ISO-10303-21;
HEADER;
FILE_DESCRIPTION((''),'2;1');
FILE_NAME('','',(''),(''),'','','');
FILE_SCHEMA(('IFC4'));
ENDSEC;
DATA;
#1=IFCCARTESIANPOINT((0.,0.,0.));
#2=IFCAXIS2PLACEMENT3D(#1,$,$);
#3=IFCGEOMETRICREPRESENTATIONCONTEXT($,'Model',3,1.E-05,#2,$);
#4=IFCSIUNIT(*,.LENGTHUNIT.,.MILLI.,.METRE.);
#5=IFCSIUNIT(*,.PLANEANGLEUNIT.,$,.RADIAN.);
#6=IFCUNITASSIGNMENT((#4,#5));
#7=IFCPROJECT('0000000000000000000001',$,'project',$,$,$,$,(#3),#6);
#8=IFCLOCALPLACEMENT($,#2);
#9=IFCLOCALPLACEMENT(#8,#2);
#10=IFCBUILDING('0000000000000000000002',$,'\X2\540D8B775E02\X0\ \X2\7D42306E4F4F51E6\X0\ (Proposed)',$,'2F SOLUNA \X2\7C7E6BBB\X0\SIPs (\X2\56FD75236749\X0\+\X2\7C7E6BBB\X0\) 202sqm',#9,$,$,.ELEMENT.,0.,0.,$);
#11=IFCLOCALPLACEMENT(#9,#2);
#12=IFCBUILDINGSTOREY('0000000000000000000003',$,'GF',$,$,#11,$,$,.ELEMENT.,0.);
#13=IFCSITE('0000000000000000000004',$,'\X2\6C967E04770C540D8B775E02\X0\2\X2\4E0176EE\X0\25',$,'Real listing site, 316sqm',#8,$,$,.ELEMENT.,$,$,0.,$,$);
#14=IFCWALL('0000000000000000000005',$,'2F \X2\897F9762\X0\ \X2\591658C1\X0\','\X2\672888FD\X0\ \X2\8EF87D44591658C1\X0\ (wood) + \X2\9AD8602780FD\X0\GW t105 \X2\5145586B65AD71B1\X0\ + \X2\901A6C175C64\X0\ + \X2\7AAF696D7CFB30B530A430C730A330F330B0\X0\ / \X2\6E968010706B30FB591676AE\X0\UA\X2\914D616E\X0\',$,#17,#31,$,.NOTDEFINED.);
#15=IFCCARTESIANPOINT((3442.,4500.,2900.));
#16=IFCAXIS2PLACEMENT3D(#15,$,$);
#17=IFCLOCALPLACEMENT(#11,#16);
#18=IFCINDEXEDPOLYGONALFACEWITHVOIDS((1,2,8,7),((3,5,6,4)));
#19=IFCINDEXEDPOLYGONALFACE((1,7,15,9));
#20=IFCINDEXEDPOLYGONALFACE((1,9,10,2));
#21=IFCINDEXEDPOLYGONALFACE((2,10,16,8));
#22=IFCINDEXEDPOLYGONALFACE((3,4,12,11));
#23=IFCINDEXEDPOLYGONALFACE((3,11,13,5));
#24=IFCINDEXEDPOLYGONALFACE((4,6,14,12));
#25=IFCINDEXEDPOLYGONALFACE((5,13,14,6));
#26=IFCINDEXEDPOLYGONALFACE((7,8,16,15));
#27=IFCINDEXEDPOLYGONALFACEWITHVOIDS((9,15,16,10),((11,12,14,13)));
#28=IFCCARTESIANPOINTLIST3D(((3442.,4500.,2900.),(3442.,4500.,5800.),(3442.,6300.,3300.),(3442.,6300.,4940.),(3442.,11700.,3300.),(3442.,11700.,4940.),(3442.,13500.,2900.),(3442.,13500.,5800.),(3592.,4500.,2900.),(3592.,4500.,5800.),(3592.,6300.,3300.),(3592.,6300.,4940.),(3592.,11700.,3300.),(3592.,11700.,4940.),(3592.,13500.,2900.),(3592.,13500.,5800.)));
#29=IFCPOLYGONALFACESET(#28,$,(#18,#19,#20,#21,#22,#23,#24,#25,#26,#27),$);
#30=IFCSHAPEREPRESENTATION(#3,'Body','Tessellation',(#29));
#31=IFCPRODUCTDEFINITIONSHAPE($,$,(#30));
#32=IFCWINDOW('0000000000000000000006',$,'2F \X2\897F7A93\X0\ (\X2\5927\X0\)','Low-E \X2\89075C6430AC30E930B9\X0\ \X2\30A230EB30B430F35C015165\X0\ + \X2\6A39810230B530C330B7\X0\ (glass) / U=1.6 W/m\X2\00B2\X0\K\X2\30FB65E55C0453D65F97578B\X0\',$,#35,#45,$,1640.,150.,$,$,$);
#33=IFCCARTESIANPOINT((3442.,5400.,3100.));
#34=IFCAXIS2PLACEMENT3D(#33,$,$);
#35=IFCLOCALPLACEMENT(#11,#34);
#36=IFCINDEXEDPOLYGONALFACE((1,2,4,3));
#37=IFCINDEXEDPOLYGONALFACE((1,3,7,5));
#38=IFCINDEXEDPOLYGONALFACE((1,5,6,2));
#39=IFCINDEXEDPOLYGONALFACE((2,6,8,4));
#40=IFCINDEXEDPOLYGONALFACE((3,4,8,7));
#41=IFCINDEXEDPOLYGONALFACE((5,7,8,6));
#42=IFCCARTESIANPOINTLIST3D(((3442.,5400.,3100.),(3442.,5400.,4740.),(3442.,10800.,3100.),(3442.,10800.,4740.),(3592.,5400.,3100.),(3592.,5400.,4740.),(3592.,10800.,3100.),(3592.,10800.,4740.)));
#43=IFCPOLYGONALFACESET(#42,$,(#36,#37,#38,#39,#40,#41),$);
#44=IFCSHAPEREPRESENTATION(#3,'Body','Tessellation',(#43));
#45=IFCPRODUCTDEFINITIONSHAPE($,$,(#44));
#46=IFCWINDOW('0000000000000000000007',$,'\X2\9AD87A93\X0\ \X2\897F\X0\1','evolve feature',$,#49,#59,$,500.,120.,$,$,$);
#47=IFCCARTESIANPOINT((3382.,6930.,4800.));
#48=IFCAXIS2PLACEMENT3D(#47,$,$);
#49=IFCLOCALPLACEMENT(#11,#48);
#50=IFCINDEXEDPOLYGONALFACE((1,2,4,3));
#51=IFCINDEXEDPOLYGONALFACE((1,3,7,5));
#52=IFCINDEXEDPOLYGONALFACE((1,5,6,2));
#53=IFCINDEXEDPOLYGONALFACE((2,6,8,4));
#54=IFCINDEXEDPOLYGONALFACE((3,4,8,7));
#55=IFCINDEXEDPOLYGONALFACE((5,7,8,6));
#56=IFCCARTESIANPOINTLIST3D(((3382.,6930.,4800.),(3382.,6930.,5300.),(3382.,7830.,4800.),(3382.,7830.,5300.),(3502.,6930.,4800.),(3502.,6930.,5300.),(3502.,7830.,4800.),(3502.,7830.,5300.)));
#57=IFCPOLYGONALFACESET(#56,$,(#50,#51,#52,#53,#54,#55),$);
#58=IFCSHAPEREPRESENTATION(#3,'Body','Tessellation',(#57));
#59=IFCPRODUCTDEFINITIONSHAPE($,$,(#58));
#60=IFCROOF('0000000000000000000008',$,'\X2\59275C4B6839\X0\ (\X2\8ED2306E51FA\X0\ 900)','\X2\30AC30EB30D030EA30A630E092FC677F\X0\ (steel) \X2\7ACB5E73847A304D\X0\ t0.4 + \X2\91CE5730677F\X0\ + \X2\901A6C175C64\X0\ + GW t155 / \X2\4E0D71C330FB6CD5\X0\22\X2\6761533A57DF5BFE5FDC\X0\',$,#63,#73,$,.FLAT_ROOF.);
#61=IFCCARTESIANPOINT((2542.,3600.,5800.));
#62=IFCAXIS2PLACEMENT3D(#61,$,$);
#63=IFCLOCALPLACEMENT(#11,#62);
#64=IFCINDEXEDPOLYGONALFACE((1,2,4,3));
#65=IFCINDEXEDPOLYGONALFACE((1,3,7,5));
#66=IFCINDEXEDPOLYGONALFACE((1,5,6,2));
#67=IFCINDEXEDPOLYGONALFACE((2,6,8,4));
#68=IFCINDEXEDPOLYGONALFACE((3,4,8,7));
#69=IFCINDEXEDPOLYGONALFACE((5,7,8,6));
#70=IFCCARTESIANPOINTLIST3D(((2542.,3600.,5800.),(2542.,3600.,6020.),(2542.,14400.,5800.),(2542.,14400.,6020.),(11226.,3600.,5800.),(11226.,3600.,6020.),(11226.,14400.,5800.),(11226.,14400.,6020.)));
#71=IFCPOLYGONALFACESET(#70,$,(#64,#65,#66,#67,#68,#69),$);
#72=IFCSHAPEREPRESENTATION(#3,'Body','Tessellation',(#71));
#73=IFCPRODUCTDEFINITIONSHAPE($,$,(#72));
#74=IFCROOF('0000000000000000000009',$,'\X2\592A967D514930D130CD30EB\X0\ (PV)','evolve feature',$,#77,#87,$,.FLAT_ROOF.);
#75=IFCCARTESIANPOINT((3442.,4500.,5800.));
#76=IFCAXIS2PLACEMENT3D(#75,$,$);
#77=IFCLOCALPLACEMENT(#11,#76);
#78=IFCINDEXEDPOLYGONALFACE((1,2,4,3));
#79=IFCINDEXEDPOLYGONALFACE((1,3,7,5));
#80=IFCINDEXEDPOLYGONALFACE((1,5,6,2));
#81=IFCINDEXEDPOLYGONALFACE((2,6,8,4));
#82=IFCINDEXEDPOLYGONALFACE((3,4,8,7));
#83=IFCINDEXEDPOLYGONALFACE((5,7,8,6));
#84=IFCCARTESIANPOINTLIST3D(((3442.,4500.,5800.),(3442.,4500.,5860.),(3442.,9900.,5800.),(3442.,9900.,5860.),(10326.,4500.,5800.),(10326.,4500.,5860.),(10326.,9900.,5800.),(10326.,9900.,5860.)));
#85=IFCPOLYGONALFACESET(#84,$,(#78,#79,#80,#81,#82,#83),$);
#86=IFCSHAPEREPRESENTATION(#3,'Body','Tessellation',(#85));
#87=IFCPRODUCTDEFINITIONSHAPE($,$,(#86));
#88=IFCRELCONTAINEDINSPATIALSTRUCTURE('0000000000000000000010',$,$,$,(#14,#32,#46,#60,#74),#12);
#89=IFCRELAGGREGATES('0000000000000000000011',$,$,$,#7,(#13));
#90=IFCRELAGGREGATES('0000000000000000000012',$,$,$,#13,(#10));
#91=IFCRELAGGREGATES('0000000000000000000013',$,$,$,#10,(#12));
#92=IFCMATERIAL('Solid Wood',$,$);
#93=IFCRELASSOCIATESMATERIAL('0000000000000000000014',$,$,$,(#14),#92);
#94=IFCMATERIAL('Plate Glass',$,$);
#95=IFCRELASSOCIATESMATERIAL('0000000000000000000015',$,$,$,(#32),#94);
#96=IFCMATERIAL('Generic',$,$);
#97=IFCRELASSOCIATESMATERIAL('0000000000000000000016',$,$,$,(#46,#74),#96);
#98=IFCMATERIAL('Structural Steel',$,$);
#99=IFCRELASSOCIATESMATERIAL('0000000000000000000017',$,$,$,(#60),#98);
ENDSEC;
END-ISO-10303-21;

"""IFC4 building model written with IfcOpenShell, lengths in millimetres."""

from ifc_helpers import new_model, si_unit, frame, frame_2d, origin, place, context, project, spatial, rectangle, extrude, material, element, fill, save


model = new_model("IFC4")

# Units and contexts
model_context = context("Model", 3, precision=1e-05, world=origin())
ifc_project = project(units=[si_unit("LENGTHUNIT", "METRE", prefix="MILLI"), si_unit("PLANEANGLEUNIT", "RADIAN")], contexts=[model_context])

# Site, building, storey
site_placement = place(None, origin())
site = spatial("IfcSite", under=ifc_project, at=site_placement, Name="沖縄県名護市2丁目25", ObjectType="Real listing site, 316sqm", CompositionType="ELEMENT", RefElevation=0.0)
building_placement = place(site_placement, origin())
building = spatial("IfcBuilding", under=site, at=building_placement, Name="名護市 終の住処 (Proposed)", ObjectType="2F SOLUNA 籾殻SIPs (国産杉+籾殻) 202sqm", CompositionType="ELEMENT", ElevationOfRefHeight=0.0, ElevationOfTerrain=0.0)
storey_placement = place(building_placement, origin())
storey = spatial("IfcBuildingStorey", under=building, at=storey_placement, Name="GF", CompositionType="ELEMENT", Elevation=0.0)

# Shared definitions
ifc_material_1 = material(Name="Solid Wood")
ifc_material_2 = material(Name="Generic")

# Shared definitions
ifc_material_3 = material(Name="Plate Glass")

# Wall, openings, windows
wall_1_placement = place(storey_placement, frame((3442.0, 4500.0, 2900.0)))
wall_1 = element("IfcWall", 1, at=wall_1_placement, inside=storey, material=ifc_material_1, Name="2F 西面 外壁", Description="木製 軸組外壁 (wood) + 高性能GW t105 充填断熱 + 通気層 + 窯業系サイディング / 準耐火・外皮UA配慮", PredefinedType="NOTDEFINED", context=model_context, shape_type="SweptSolid", body=[
    extrude(rectangle(XDim=150.0, YDim=9000.0, at=frame_2d((75.0, 4500.0))), frame((3442.0, 4500.0, 2900.0)), (0.0, 0.0, 1.0), 2900.0),
])
opening_1_placement = place(storey_placement, frame((3442.0, 5400.0, 3100.0)))
opening_1 = element("IfcOpeningElement", 2, at=opening_1_placement, cuts=wall_1, PredefinedType="NOTDEFINED", context=model_context, shape_type="SweptSolid", body=[
    extrude(rectangle(XDim=150.0, YDim=5400.0, at=frame_2d((75.0, 2700.0))), frame((3442.0, 5400.0, 3100.0)), (0.0, 0.0, 1.0), 1640.0),
])
opening_2_placement = place(storey_placement, frame((3382.0, 6930.0, 4800.0)))
opening_2 = element("IfcOpeningElement", 3, at=opening_2_placement, cuts=wall_1, PredefinedType="NOTDEFINED", context=model_context, shape_type="SweptSolid", body=[
    extrude(rectangle(XDim=120.0, YDim=900.0, at=frame_2d((60.0, 450.0))), frame((3382.0, 6930.0, 4800.0)), (0.0, 0.0, 1.0), 500.0),
])
window_1_placement = place(storey_placement, frame((3442.0, 5400.0, 3100.0)))
window_1 = element("IfcWindow", 4, at=window_1_placement, inside=storey, material=ifc_material_3, Name="2F 西窓 (大)", Description="Low-E 複層ガラス アルゴン封入 + 樹脂サッシ (glass) / U=1.6 W/m²K・日射取得型", OverallHeight=1640.0, OverallWidth=150.0, context=model_context, shape_type="SweptSolid", body=[
    extrude(rectangle(XDim=150.0, YDim=5400.0, at=frame_2d((75.0, 2700.0))), frame((3442.0, 5400.0, 3100.0)), (0.0, 0.0, 1.0), 1640.0),
])
fill(opening_1, window_1)
window_2_placement = place(storey_placement, frame((3382.0, 6930.0, 4800.0)))
window_2 = element("IfcWindow", 5, at=window_2_placement, inside=storey, material=ifc_material_2, Name="高窓 西1", Description="evolve feature", OverallHeight=500.0, OverallWidth=120.0, context=model_context, shape_type="SweptSolid", body=[
    extrude(rectangle(XDim=120.0, YDim=900.0, at=frame_2d((60.0, 450.0))), frame((3382.0, 6930.0, 4800.0)), (0.0, 0.0, 1.0), 500.0),
])
fill(opening_2, window_2)

# Roofs
ifc_material_4 = material(Name="Structural Steel")
roof_1_placement = place(storey_placement, frame((2542.0, 3600.0, 5800.0)))
element("IfcRoof", 6, at=roof_1_placement, inside=storey, material=ifc_material_4, Name="大屋根 (軒の出 900)", Description="ガルバリウム鋼板 (steel) 立平葺き t0.4 + 野地板 + 通気層 + GW t155 / 不燃・法22条区域対応", PredefinedType="FLAT_ROOF", context=model_context, shape_type="SweptSolid", body=[
    extrude(rectangle(XDim=8684.0, YDim=10800.0, at=frame_2d((4342.0, 5400.0))), frame((2542.0, 3600.0, 5800.0)), (0.0, 0.0, 1.0), 220.0),
])
roof_2_placement = place(storey_placement, frame((3442.0, 4500.0, 5800.0)))
element("IfcRoof", 7, at=roof_2_placement, inside=storey, material=ifc_material_2, Name="太陽光パネル (PV)", Description="evolve feature", PredefinedType="FLAT_ROOF", context=model_context, shape_type="SweptSolid", body=[
    extrude(rectangle(XDim=6884.0, YDim=5400.0, at=frame_2d((3442.0, 2700.0))), frame((3442.0, 4500.0, 5800.0)), (0.0, 0.0, 1.0), 60.0),
])

save(model, "model.ifc")
